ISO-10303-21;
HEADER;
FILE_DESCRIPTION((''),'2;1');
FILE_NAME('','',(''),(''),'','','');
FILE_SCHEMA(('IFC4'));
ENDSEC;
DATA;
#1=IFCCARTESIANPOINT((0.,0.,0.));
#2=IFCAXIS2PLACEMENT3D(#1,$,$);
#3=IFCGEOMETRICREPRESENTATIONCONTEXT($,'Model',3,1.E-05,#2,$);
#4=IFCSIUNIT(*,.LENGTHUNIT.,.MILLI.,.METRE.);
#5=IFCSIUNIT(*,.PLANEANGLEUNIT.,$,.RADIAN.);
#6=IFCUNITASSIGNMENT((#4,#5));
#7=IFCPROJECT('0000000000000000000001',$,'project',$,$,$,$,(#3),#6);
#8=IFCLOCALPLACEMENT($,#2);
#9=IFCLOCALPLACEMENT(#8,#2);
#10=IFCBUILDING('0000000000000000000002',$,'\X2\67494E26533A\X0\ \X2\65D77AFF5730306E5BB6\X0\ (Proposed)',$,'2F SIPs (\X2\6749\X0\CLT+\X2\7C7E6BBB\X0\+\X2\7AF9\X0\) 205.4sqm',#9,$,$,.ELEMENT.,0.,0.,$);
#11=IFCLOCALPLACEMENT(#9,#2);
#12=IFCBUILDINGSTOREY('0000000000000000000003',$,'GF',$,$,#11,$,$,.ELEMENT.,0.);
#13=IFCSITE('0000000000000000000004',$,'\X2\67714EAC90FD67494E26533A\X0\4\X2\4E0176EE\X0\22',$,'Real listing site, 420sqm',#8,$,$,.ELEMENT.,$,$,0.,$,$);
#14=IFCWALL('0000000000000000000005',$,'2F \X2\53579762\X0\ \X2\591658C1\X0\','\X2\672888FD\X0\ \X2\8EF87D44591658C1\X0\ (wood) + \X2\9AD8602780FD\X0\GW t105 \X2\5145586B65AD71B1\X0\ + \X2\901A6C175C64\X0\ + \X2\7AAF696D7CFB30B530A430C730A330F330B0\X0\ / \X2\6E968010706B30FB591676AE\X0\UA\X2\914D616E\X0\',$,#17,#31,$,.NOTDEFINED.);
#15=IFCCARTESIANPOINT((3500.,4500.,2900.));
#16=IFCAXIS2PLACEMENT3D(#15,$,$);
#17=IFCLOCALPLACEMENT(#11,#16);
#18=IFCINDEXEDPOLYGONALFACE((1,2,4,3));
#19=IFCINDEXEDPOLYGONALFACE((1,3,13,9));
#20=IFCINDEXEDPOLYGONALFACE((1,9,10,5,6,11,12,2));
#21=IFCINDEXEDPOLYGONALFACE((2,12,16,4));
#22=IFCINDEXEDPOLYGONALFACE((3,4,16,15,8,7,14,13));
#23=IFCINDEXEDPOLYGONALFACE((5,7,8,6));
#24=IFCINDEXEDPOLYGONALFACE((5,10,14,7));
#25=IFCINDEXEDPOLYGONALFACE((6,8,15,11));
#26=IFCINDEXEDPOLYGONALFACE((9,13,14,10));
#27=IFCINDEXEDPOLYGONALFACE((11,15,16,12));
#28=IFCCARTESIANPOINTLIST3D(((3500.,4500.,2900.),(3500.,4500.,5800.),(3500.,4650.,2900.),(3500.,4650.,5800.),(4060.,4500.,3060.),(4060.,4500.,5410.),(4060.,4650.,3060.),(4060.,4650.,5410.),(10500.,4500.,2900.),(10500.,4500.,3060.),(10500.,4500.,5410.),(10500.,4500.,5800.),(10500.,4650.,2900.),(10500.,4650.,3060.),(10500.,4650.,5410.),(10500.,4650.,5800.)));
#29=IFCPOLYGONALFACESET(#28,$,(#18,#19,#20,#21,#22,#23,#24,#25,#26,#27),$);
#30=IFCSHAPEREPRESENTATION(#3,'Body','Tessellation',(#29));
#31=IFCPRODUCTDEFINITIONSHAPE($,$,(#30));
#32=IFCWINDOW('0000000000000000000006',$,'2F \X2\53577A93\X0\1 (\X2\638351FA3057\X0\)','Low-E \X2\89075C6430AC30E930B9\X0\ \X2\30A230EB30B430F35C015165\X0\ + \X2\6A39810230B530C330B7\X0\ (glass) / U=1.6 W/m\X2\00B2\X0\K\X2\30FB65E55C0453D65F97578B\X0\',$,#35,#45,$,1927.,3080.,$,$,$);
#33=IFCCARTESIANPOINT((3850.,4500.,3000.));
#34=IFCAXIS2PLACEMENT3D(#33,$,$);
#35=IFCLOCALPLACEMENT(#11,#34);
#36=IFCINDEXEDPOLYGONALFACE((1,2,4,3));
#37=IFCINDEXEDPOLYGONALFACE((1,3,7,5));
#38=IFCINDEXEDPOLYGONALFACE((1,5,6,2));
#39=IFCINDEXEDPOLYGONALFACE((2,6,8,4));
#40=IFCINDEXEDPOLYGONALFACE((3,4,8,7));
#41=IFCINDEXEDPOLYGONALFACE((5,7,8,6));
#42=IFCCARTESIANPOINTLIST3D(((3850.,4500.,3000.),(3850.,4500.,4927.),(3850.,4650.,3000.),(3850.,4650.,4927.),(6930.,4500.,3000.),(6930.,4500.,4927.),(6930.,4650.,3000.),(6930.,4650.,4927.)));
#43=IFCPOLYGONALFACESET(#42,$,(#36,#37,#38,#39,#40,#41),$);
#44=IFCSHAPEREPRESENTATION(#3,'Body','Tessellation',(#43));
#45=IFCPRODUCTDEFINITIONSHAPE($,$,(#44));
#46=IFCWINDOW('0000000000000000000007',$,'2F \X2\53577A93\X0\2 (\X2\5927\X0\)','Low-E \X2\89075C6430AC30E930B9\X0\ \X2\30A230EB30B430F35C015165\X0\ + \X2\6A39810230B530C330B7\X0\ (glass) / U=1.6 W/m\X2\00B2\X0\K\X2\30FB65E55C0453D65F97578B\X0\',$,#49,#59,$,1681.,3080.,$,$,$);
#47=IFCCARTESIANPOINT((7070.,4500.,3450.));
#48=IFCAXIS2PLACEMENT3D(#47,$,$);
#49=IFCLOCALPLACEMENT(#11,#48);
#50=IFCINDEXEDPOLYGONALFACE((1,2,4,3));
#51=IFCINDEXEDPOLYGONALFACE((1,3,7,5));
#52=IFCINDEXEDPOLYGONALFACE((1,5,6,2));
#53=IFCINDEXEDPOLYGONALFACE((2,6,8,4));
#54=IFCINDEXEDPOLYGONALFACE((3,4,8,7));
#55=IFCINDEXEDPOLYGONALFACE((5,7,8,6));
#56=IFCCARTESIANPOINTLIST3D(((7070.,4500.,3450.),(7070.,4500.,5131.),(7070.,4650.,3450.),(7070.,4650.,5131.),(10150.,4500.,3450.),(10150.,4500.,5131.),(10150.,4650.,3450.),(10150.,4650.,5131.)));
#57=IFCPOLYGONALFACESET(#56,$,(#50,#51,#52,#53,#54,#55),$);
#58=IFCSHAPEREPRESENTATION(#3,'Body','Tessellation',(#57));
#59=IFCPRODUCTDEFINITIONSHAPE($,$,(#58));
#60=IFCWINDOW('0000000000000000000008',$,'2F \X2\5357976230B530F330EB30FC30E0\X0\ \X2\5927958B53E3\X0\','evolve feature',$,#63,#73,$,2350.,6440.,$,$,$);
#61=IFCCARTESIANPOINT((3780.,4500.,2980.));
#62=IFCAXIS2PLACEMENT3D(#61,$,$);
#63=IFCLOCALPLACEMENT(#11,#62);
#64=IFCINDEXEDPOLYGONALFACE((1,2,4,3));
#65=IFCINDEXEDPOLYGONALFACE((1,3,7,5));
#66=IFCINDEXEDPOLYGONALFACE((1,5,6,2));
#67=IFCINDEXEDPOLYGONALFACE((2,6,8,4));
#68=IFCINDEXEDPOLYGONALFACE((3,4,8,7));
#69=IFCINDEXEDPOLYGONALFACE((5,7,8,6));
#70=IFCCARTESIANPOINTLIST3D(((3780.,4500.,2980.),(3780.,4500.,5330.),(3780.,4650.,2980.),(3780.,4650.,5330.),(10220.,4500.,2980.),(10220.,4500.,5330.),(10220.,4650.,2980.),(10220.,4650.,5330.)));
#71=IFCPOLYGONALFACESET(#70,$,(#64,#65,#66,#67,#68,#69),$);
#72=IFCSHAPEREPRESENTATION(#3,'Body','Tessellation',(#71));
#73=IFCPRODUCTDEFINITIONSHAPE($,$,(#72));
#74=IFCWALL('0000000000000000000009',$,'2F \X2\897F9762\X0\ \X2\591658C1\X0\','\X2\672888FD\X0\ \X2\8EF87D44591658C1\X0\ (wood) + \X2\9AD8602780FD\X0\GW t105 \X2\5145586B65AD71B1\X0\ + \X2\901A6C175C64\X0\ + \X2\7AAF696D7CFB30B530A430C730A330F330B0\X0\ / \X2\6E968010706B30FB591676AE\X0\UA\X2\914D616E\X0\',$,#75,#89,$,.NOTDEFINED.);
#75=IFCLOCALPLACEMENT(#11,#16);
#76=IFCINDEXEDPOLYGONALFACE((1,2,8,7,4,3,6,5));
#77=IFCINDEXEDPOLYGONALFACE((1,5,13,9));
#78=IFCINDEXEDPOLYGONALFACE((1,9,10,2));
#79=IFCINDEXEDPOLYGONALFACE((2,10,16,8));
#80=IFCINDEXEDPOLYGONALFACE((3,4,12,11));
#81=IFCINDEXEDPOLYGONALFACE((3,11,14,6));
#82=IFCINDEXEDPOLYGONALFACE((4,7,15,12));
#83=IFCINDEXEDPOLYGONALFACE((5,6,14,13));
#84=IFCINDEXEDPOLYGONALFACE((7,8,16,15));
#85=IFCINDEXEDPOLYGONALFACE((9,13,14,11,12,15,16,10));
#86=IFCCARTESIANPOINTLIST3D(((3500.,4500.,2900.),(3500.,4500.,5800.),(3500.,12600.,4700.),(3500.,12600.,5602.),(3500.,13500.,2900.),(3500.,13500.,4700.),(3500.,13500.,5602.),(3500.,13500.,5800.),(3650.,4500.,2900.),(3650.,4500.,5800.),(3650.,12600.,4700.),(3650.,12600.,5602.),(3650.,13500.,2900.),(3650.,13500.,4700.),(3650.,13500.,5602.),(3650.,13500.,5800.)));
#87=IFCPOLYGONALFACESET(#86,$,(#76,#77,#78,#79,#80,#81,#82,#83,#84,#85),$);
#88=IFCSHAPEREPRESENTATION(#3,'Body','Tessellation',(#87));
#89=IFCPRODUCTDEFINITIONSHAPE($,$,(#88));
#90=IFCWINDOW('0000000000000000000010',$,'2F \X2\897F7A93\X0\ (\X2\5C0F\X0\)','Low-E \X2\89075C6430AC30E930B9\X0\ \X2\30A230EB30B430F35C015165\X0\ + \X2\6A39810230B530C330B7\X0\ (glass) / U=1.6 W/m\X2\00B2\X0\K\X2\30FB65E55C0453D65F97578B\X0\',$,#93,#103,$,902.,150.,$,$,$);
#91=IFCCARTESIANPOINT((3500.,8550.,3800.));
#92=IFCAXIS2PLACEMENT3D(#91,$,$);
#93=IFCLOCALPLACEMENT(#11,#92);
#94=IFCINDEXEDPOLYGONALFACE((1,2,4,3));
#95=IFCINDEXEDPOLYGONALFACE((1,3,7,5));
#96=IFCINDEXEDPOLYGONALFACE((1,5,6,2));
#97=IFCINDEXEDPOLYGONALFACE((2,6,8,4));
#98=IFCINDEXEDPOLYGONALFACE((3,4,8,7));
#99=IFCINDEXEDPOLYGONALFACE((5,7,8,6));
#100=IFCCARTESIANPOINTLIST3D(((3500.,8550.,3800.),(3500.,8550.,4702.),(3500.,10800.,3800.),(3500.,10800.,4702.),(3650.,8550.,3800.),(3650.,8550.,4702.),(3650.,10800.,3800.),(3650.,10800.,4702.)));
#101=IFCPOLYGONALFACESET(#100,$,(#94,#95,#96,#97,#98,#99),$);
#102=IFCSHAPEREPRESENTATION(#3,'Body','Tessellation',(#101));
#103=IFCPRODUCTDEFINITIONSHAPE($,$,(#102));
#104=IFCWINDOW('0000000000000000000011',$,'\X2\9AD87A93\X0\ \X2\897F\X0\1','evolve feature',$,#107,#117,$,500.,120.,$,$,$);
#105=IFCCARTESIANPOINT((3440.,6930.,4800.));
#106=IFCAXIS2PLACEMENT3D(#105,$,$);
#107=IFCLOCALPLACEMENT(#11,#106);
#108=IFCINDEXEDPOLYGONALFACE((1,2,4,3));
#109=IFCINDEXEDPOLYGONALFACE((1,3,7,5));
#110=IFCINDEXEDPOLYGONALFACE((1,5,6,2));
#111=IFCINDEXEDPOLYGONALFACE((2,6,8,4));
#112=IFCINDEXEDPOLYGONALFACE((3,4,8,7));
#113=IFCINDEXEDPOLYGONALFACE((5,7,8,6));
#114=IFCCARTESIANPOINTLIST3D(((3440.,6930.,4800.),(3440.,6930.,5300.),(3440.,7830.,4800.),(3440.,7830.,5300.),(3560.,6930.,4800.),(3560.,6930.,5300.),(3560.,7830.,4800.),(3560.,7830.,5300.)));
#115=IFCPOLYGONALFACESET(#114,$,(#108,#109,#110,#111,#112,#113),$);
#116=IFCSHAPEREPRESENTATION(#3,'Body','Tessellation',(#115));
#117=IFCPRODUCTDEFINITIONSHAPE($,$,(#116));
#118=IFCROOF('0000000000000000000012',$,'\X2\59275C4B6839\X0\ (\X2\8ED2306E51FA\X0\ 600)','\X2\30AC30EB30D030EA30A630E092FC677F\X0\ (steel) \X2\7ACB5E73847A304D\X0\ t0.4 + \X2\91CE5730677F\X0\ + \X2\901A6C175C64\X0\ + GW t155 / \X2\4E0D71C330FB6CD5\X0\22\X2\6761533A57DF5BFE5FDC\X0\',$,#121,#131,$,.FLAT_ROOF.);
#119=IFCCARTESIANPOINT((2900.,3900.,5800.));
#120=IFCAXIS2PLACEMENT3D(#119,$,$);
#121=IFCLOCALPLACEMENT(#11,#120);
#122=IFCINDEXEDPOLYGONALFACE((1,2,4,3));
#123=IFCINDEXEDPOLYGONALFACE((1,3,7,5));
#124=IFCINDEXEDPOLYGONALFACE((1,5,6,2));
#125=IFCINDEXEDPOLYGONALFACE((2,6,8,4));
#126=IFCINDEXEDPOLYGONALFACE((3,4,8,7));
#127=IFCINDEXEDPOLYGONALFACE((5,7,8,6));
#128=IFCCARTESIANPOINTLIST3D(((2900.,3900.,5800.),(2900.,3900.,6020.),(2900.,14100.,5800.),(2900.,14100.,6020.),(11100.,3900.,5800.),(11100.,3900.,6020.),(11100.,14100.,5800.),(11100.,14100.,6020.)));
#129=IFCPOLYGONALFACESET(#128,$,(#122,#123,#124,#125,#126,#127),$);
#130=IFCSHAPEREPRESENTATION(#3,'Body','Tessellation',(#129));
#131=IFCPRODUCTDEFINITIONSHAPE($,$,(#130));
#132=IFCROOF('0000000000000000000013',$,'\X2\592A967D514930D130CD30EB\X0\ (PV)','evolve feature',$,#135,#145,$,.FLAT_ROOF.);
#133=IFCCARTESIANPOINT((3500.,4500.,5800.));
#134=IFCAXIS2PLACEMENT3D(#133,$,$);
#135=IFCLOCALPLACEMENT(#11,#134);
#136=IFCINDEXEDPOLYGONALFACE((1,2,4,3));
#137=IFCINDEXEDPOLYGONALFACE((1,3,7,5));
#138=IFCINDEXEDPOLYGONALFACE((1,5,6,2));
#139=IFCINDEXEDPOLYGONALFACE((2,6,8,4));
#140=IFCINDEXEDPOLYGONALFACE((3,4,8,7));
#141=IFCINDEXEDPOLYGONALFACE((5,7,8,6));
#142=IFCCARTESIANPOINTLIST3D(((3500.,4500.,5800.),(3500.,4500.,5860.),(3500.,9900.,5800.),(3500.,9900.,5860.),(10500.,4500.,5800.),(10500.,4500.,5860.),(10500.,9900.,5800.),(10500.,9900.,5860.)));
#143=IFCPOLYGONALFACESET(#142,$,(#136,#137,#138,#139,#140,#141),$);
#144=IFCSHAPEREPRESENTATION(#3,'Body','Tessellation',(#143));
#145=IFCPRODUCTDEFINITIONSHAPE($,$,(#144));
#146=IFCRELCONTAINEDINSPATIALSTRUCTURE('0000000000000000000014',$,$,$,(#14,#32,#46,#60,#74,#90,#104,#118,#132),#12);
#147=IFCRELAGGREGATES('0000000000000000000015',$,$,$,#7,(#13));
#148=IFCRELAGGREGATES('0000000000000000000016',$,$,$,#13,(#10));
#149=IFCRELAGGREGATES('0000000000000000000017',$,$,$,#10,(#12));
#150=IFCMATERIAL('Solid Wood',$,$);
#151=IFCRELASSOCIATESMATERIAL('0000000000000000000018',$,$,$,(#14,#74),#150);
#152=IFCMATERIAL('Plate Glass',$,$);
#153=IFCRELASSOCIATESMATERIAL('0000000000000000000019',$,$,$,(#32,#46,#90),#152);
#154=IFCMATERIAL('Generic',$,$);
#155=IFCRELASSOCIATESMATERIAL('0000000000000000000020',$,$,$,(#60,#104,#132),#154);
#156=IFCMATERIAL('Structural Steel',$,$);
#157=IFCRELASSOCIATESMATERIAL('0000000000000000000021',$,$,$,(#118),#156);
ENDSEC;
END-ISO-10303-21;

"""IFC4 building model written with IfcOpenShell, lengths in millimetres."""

from ifc_helpers import new_model, si_unit, frame, frame_2d, origin, place, context, project, spatial, rectangle, extrude, material, element, fill, save


model = new_model("IFC4")

# Units and contexts
model_context = context("Model", 3, precision=1e-05, world=origin())
ifc_project = project(units=[si_unit("LENGTHUNIT", "METRE", prefix="MILLI"), si_unit("PLANEANGLEUNIT", "RADIAN")], contexts=[model_context])

# Site, building, storey
site_placement = place(None, origin())
site = spatial("IfcSite", under=ifc_project, at=site_placement, Name="東京都杉並区4丁目22", ObjectType="Real listing site, 420sqm", CompositionType="ELEMENT", RefElevation=0.0)
building_placement = place(site_placement, origin())
building = spatial("IfcBuilding", under=site, at=building_placement, Name="杉並区 旗竿地の家 (Proposed)", ObjectType="2F SIPs (杉CLT+籾殻+竹) 205.4sqm", CompositionType="ELEMENT", ElevationOfRefHeight=0.0, ElevationOfTerrain=0.0)
storey_placement = place(building_placement, origin())
storey = spatial("IfcBuildingStorey", under=building, at=storey_placement, Name="GF", CompositionType="ELEMENT", Elevation=0.0)

# Shared definitions
ifc_material_1 = material(Name="Solid Wood")
ifc_material_2 = material(Name="Generic")

# Shared definitions
ifc_material_3 = material(Name="Plate Glass")

# Walls, openings, windows
wall_1_placement = place(storey_placement, frame((3500.0, 4500.0, 2900.0)))
wall_1 = element("IfcWall", 1, at=wall_1_placement, inside=storey, material=ifc_material_1, Name="2F 南面 外壁", Description="木製 軸組外壁 (wood) + 高性能GW t105 充填断熱 + 通気層 + 窯業系サイディング / 準耐火・外皮UA配慮", PredefinedType="NOTDEFINED", context=model_context, shape_type="SweptSolid", body=[
    extrude(rectangle(XDim=7000.0, YDim=150.0, at=frame_2d((3500.0, 75.0))), frame((3500.0, 4500.0, 2900.0)), (0.0, 0.0, 1.0), 2900.0),
])
opening_1_placement = place(storey_placement, frame((3850.0, 4500.0, 3000.0)))
opening_1 = element("IfcOpeningElement", 2, at=opening_1_placement, cuts=wall_1, PredefinedType="NOTDEFINED", context=model_context, shape_type="SweptSolid", body=[
    extrude(rectangle(XDim=3080.0, YDim=150.0, at=frame_2d((1540.0, 75.0))), frame((3850.0, 4500.0, 3000.0)), (0.0, 0.0, 1.0), 1927.0),
])
opening_2_placement = place(storey_placement, frame((7070.0, 4500.0, 3450.0)))
opening_2 = element("IfcOpeningElement", 3, at=opening_2_placement, cuts=wall_1, PredefinedType="NOTDEFINED", context=model_context, shape_type="SweptSolid", body=[
    extrude(rectangle(XDim=3080.0, YDim=150.0, at=frame_2d((1540.0, 75.0))), frame((7070.0, 4500.0, 3450.0)), (0.0, 0.0, 1.0), 1681.0),
])
opening_3_placement = place(storey_placement, frame((3780.0, 4500.0, 2980.0)))
opening_3 = element("IfcOpeningElement", 4, at=opening_3_placement, cuts=wall_1, PredefinedType="NOTDEFINED", context=model_context, shape_type="SweptSolid", body=[
    extrude(rectangle(XDim=6440.0, YDim=150.0, at=frame_2d((3220.0, 75.0))), frame((3780.0, 4500.0, 2980.0)), (0.0, 0.0, 1.0), 2350.0),
])
window_1_placement = place(storey_placement, frame((3850.0, 4500.0, 3000.0)))
window_1 = element("IfcWindow", 5, at=window_1_placement, inside=storey, material=ifc_material_3, Name="2F 南窓1 (掃出し)", Description="Low-E 複層ガラス アルゴン封入 + 樹脂サッシ (glass) / U=1.6 W/m²K・日射取得型", OverallHeight=1927.0, OverallWidth=3080.0, context=model_context, shape_type="SweptSolid", body=[
    extrude(rectangle(XDim=3080.0, YDim=150.0, at=frame_2d((1540.0, 75.0))), frame((3850.0, 4500.0, 3000.0)), (0.0, 0.0, 1.0), 1927.0),
])
fill(opening_1, window_1)
window_2_placement = place(storey_placement, frame((7070.0, 4500.0, 3450.0)))
window_2 = element("IfcWindow", 6, at=window_2_placement, inside=storey, material=ifc_material_3, Name="2F 南窓2 (大)", Description="Low-E 複層ガラス アルゴン封入 + 樹脂サッシ (glass) / U=1.6 W/m²K・日射取得型", OverallHeight=1681.0, OverallWidth=3080.0, context=model_context, shape_type="SweptSolid", body=[
    extrude(rectangle(XDim=3080.0, YDim=150.0, at=frame_2d((1540.0, 75.0))), frame((7070.0, 4500.0, 3450.0)), (0.0, 0.0, 1.0), 1681.0),
])
fill(opening_2, window_2)
window_3_placement = place(storey_placement, frame((3780.0, 4500.0, 2980.0)))
window_3 = element("IfcWindow", 7, at=window_3_placement, inside=storey, material=ifc_material_2, Name="2F 南面サンルーム 大開口", Description="evolve feature", OverallHeight=2350.0, OverallWidth=6440.0, context=model_context, shape_type="SweptSolid", body=[
    extrude(rectangle(XDim=6440.0, YDim=150.0, at=frame_2d((3220.0, 75.0))), frame((3780.0, 4500.0, 2980.0)), (0.0, 0.0, 1.0), 2350.0),
])
fill(opening_3, window_3)
wall_2_placement = place(storey_placement, frame((3500.0, 4500.0, 2900.0)))
wall_2 = element("IfcWall", 8, at=wall_2_placement, inside=storey, material=ifc_material_1, Name="2F 西面 外壁", Description="木製 軸組外壁 (wood) + 高性能GW t105 充填断熱 + 通気層 + 窯業系サイディング / 準耐火・外皮UA配慮", PredefinedType="NOTDEFINED", context=model_context, shape_type="SweptSolid", body=[
    extrude(rectangle(XDim=150.0, YDim=9000.0, at=frame_2d((75.0, 4500.0))), frame((3500.0, 4500.0, 2900.0)), (0.0, 0.0, 1.0), 2900.0),
])
opening_4_placement = place(storey_placement, frame((3500.0, 8550.0, 3800.0)))
opening_4 = element("IfcOpeningElement", 9, at=opening_4_placement, cuts=wall_2, PredefinedType="NOTDEFINED", context=model_context, shape_type="SweptSolid", body=[
    extrude(rectangle(XDim=150.0, YDim=2250.0, at=frame_2d((75.0, 1125.0))), frame((3500.0, 8550.0, 3800.0)), (0.0, 0.0, 1.0), 902.0),
])
opening_5_placement = place(storey_placement, frame((3440.0, 6930.0, 4800.0)))
opening_5 = element("IfcOpeningElement", 10, at=opening_5_placement, cuts=wall_2, PredefinedType="NOTDEFINED", context=model_context, shape_type="SweptSolid", body=[
    extrude(rectangle(XDim=120.0, YDim=900.0, at=frame_2d((60.0, 450.0))), frame((3440.0, 6930.0, 4800.0)), (0.0, 0.0, 1.0), 500.0),
])
window_4_placement = place(storey_placement, frame((3500.0, 8550.0, 3800.0)))
window_4 = element("IfcWindow", 11, at=window_4_placement, inside=storey, material=ifc_material_3, Name="2F 西窓 (小)", Description="Low-E 複層ガラス アルゴン封入 + 樹脂サッシ (glass) / U=1.6 W/m²K・日射取得型", OverallHeight=902.0, OverallWidth=150.0, context=model_context, shape_type="SweptSolid", body=[
    extrude(rectangle(XDim=150.0, YDim=2250.0, at=frame_2d((75.0, 1125.0))), frame((3500.0, 8550.0, 3800.0)), (0.0, 0.0, 1.0), 902.0),
])
fill(opening_4, window_4)
window_5_placement = place(storey_placement, frame((3440.0, 6930.0, 4800.0)))
window_5 = element("IfcWindow", 12, at=window_5_placement, inside=storey, material=ifc_material_2, Name="高窓 西1", Description="evolve feature", OverallHeight=500.0, OverallWidth=120.0, context=model_context, shape_type="SweptSolid", body=[
    extrude(rectangle(XDim=120.0, YDim=900.0, at=frame_2d((60.0, 450.0))), frame((3440.0, 6930.0, 4800.0)), (0.0, 0.0, 1.0), 500.0),
])
fill(opening_5, window_5)

# Roofs
ifc_material_4 = material(Name="Structural Steel")
roof_1_placement = place(storey_placement, frame((2900.0, 3900.0, 5800.0)))
element("IfcRoof", 13, at=roof_1_placement, inside=storey, material=ifc_material_4, Name="大屋根 (軒の出 600)", Description="ガルバリウム鋼板 (steel) 立平葺き t0.4 + 野地板 + 通気層 + GW t155 / 不燃・法22条区域対応", PredefinedType="FLAT_ROOF", context=model_context, shape_type="SweptSolid", body=[
    extrude(rectangle(XDim=8200.0, YDim=10200.0, at=frame_2d((4100.0, 5100.0))), frame((2900.0, 3900.0, 5800.0)), (0.0, 0.0, 1.0), 220.0),
])
roof_2_placement = place(storey_placement, frame((3500.0, 4500.0, 5800.0)))
element("IfcRoof", 14, at=roof_2_placement, inside=storey, material=ifc_material_2, Name="太陽光パネル (PV)", Description="evolve feature", PredefinedType="FLAT_ROOF", context=model_context, shape_type="SweptSolid", body=[
    extrude(rectangle(XDim=7000.0, YDim=5400.0, at=frame_2d((3500.0, 2700.0))), frame((3500.0, 4500.0, 5800.0)), (0.0, 0.0, 1.0), 60.0),
])

save(model, "model.ifc")
